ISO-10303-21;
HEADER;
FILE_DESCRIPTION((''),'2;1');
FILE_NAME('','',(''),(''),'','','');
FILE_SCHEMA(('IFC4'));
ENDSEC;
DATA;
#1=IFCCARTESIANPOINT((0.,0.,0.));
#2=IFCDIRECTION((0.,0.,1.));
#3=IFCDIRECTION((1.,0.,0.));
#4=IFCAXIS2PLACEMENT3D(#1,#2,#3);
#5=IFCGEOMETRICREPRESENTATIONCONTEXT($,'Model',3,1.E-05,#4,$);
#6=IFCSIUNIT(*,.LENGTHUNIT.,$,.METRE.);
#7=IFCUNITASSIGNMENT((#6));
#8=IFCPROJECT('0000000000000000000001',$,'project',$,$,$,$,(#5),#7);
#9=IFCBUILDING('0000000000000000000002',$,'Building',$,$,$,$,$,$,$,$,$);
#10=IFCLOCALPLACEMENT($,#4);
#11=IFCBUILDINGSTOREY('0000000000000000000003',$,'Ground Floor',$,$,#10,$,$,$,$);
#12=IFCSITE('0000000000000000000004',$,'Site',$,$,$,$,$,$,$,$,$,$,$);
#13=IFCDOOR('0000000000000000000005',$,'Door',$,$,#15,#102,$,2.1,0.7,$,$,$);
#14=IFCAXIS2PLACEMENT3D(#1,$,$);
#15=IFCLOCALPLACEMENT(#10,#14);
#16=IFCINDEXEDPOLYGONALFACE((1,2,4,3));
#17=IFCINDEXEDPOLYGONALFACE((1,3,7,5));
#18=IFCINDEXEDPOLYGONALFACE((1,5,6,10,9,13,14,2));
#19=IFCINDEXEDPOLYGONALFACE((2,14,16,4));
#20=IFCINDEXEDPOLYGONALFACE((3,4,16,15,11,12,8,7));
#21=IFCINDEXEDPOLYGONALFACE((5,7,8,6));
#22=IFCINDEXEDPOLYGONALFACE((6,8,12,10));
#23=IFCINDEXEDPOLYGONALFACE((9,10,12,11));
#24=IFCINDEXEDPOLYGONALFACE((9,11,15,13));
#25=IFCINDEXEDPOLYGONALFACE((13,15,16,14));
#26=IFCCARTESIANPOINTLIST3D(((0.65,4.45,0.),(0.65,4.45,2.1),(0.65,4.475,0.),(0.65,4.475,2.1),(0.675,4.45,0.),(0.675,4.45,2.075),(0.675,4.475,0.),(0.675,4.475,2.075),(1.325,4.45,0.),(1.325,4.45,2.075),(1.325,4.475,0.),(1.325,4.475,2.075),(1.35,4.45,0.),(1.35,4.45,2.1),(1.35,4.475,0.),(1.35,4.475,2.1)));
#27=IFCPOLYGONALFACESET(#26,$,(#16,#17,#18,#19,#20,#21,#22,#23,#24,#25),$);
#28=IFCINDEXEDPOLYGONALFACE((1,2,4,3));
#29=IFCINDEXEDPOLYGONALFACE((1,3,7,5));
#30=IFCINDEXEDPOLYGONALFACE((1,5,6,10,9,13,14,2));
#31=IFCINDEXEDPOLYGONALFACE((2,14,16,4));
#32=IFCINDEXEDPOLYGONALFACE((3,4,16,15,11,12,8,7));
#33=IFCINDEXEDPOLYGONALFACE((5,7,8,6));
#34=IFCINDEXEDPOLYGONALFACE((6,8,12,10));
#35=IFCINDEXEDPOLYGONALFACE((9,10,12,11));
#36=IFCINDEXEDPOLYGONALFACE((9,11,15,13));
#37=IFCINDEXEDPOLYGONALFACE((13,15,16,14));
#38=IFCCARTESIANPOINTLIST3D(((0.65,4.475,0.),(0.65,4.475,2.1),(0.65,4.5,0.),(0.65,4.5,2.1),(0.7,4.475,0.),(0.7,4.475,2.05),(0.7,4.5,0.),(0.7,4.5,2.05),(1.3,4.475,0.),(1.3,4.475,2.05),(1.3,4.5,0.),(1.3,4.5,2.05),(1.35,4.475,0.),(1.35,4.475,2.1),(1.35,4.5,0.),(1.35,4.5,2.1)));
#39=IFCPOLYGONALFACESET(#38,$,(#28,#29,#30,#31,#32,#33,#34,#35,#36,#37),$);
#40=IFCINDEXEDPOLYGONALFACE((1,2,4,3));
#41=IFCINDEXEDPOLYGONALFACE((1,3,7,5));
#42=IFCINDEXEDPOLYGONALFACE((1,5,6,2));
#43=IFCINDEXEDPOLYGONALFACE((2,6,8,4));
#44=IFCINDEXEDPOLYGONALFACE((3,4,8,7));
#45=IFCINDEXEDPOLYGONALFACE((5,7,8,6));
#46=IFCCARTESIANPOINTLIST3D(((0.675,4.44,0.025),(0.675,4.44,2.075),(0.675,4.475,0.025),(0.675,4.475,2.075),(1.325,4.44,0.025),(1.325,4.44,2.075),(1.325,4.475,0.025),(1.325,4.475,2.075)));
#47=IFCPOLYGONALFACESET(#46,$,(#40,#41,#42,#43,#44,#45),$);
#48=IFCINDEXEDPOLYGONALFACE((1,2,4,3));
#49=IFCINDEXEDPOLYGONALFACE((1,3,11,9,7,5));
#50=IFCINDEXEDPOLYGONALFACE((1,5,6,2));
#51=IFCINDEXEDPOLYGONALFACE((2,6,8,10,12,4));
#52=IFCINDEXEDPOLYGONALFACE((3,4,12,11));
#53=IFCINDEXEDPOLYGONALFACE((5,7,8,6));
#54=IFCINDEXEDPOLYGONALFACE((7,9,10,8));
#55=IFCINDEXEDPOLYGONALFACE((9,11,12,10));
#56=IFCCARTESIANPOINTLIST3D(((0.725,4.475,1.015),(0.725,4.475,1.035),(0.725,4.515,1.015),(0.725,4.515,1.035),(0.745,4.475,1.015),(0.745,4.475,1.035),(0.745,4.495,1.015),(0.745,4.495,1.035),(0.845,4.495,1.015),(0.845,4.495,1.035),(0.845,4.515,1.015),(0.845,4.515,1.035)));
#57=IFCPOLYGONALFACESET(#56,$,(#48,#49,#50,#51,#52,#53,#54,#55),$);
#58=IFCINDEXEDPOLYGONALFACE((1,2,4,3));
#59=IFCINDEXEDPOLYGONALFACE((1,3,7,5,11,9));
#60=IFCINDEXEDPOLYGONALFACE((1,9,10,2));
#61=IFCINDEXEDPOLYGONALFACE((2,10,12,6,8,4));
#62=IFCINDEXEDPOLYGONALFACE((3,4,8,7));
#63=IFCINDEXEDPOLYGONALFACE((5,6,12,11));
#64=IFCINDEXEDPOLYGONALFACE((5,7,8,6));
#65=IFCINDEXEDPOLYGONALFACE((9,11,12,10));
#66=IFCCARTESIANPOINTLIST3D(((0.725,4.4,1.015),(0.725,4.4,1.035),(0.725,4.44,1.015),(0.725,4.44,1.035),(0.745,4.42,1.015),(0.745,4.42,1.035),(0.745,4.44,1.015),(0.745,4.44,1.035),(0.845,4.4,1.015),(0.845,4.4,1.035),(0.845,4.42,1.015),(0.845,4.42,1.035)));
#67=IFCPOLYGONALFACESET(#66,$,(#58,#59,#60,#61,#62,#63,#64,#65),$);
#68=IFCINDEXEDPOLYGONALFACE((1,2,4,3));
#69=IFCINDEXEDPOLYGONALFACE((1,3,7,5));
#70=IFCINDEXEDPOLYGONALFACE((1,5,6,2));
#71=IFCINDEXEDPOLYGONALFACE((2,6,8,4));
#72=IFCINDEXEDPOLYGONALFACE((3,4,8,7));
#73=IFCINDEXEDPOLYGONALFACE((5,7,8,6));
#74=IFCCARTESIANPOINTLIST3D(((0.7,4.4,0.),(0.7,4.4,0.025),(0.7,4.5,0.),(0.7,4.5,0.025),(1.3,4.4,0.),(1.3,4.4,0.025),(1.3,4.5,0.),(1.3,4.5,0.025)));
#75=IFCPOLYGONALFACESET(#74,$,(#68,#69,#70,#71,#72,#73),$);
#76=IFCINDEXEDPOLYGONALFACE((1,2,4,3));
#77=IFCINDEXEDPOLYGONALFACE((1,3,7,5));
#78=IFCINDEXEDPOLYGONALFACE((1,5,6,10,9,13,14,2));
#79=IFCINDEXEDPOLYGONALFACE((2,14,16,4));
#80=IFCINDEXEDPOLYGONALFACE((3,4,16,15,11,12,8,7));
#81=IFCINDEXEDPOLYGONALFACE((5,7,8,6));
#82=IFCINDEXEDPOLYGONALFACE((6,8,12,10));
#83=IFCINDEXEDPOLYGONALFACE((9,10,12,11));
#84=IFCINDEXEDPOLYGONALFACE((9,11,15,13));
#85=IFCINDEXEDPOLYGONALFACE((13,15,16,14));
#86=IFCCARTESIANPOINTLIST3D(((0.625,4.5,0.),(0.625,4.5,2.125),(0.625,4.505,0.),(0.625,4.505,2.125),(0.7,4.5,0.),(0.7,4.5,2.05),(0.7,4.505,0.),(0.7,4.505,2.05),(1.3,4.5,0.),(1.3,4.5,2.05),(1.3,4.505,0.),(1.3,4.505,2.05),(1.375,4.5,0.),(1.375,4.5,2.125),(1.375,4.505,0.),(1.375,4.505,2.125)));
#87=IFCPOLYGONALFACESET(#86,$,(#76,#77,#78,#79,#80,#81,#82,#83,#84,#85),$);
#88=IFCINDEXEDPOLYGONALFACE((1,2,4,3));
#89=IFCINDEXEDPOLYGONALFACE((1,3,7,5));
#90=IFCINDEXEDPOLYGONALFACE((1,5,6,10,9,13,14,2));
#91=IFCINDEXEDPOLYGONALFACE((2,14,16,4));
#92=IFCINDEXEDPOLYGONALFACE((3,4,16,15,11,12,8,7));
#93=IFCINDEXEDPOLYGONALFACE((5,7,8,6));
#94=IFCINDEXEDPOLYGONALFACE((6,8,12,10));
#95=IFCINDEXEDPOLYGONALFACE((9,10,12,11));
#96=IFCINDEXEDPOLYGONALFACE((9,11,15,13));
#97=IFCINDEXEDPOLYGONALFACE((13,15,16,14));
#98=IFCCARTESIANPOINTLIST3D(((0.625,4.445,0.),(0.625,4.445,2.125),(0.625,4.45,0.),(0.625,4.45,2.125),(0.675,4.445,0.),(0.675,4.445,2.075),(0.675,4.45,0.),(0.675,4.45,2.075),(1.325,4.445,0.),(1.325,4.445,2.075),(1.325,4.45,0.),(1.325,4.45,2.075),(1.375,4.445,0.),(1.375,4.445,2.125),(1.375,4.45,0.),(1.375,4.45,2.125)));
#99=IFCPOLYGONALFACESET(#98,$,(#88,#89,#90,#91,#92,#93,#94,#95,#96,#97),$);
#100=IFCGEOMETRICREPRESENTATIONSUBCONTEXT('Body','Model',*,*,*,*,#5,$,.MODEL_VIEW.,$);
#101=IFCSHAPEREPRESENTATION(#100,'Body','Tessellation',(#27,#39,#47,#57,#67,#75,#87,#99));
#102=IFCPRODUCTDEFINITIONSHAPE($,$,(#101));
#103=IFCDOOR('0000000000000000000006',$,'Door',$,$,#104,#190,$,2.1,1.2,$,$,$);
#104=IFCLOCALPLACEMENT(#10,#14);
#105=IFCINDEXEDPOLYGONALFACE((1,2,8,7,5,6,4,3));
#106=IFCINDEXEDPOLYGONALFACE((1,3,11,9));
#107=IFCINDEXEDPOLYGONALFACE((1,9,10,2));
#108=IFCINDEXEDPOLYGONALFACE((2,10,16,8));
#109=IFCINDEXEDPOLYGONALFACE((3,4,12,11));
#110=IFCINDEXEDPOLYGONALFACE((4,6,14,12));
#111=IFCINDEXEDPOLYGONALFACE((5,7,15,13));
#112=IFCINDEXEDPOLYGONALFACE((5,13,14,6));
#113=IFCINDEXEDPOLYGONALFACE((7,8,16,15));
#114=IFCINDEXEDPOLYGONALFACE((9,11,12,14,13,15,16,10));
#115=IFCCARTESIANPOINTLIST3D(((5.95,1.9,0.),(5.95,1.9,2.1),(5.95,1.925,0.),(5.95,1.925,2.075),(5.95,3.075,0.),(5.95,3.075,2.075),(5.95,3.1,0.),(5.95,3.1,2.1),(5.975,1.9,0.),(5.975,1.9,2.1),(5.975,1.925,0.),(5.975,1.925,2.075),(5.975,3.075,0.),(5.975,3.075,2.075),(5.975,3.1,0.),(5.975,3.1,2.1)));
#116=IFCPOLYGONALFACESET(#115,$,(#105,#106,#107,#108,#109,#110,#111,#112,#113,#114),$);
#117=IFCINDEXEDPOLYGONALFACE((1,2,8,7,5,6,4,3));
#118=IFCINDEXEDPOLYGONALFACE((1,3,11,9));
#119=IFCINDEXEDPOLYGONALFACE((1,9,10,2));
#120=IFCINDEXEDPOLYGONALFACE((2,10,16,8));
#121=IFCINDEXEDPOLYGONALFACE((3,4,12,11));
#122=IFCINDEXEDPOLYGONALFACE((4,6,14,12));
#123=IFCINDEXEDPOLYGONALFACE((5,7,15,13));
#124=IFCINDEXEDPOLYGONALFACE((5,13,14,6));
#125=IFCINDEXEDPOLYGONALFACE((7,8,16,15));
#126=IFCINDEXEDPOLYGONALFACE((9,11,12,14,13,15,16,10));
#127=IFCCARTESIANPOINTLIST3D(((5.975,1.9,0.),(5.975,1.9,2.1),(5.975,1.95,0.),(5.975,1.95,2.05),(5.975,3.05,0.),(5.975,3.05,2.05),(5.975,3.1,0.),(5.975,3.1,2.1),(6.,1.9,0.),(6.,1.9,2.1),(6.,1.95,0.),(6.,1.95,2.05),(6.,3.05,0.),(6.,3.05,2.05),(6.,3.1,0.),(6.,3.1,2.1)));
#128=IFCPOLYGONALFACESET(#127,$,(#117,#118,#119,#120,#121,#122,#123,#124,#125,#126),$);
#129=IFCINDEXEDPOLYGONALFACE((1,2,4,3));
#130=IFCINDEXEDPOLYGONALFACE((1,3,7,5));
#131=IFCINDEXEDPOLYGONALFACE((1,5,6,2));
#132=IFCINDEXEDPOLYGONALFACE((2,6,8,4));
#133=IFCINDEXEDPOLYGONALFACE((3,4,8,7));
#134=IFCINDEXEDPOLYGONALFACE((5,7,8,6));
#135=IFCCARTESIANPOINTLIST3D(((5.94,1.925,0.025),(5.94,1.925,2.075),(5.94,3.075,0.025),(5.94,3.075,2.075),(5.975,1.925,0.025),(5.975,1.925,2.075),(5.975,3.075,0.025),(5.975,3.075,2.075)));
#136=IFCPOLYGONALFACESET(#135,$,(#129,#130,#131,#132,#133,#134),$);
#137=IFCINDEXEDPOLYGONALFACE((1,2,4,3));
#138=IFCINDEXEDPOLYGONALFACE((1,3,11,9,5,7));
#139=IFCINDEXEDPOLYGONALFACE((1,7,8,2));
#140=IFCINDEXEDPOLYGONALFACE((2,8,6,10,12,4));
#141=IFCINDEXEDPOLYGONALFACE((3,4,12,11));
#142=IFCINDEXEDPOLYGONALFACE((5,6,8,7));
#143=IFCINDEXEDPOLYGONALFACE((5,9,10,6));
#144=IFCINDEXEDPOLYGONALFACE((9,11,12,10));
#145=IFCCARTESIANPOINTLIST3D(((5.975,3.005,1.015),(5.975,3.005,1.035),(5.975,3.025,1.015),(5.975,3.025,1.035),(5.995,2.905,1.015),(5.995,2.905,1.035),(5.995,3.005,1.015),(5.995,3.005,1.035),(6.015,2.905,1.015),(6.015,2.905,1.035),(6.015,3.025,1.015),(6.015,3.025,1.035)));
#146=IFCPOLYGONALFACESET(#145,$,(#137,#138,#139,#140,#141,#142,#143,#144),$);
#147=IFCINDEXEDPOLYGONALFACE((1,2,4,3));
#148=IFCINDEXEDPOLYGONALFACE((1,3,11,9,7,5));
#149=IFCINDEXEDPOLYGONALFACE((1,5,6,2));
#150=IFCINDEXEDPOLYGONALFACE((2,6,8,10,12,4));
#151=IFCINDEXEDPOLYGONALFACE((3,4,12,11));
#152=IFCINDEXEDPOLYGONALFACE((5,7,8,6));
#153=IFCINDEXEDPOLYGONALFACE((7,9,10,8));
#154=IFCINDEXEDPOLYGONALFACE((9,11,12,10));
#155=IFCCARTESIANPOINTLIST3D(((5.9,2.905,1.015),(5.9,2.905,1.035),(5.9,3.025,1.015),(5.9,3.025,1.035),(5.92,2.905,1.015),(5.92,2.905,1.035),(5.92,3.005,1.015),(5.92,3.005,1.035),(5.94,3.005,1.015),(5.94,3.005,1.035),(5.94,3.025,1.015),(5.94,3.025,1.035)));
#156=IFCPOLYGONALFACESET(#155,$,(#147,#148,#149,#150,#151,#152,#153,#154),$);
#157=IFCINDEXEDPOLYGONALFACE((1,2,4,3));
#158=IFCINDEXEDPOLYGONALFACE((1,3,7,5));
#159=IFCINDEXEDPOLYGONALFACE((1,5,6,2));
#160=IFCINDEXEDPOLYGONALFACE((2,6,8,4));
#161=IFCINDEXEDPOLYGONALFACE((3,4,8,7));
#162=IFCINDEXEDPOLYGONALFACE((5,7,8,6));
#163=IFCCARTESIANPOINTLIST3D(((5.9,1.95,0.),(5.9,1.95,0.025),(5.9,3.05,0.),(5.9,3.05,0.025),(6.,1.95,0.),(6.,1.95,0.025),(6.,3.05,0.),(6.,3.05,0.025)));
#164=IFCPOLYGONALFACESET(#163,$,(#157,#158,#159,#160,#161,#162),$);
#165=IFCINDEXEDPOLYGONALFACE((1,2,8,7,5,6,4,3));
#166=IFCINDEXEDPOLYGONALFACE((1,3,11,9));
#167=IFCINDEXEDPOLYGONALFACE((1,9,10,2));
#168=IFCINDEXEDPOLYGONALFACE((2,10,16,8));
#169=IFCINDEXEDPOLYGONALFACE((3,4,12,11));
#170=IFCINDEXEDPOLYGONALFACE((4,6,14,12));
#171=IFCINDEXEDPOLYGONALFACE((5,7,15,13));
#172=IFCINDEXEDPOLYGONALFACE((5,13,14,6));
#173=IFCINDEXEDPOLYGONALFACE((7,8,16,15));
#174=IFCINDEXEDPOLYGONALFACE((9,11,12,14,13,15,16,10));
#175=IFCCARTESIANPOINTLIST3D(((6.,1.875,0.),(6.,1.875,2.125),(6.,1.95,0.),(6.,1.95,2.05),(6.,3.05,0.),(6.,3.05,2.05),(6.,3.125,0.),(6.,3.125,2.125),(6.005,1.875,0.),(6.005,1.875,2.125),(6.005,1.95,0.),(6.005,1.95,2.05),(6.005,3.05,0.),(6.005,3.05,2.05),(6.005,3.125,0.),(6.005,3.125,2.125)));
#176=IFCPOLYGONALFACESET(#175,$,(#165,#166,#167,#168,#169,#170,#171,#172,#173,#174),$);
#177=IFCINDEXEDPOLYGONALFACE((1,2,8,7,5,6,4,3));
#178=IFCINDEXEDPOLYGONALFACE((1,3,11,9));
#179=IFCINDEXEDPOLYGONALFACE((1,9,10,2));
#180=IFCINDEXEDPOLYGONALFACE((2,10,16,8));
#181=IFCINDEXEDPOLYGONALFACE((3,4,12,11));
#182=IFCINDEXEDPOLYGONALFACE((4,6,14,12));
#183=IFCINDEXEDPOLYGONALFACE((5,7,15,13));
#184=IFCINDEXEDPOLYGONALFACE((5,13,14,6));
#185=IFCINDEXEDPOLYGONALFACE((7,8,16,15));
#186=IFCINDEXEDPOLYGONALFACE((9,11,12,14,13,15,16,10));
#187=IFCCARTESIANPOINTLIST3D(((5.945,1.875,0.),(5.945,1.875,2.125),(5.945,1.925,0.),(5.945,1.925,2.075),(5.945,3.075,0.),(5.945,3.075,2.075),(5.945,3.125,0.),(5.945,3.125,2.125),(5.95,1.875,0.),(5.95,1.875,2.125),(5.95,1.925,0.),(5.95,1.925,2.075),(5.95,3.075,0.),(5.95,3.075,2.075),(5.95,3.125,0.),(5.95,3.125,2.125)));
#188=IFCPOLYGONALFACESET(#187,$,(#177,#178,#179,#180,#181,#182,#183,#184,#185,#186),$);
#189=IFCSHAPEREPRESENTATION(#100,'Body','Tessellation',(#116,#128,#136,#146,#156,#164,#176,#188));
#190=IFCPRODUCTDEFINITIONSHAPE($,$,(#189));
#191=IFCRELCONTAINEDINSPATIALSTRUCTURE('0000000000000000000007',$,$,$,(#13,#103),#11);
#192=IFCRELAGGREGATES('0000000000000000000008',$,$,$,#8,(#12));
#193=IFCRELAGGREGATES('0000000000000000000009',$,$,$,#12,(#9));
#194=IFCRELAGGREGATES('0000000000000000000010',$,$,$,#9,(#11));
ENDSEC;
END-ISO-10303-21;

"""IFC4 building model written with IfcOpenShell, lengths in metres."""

from ifc_helpers import new_model, si_unit, frame, origin_with_axes, place, context, subcontext, project, spatial, line, indexed_curve, outline, extrude, element, save


model = new_model("IFC4")

# Units and contexts
model_context = context("Model", 3, precision=1e-05, world=origin_with_axes())
body_context = subcontext(model_context, "Body", "Model", "MODEL_VIEW")
ifc_project = project(units=[si_unit("LENGTHUNIT", "METRE")], contexts=[model_context])

# Site, building, storey
site = spatial("IfcSite", under=ifc_project, Name="Site")
building = spatial("IfcBuilding", under=site, Name="Building")
storey_placement = place(None, origin_with_axes())
storey = spatial("IfcBuildingStorey", under=building, at=storey_placement, Name="Ground Floor")

# Doors
door_1_placement = place(storey_placement, frame((1.35, 4.5, 0.0), z_axis=(0.0, 0.0, 1.0), x_axis=(-1.0, 0.0, 0.0)))
element("IfcDoor", 1, at=door_1_placement, inside=storey, Name="Door", OverallHeight=2.1, OverallWidth=0.7, context=body_context, shape_type="SweptSolid", body=[
    extrude(outline(indexed_curve([(0.0, 0.0), (0.0, 2.1), (0.7, 2.1), (0.7, 0.0), (0.675, 0.0), (0.675, 2.075), (0.025, 2.075), (0.025, 0.0)], segments=[line(1, 2, 3, 4, 5, 6, 7, 8, 1)])), frame((0.0, 0.025, 0.0), z_axis=(0.0, -1.0, 0.0), x_axis=(1.0, 0.0, 0.0)), (0.0, 0.0, -1.0), 0.025),
    extrude(outline(indexed_curve([(0.0, 0.0), (0.0, 2.1), (0.7, 2.1), (0.7, 0.0), (0.65, 0.0), (0.65, 2.05), (0.05, 2.05), (0.05, 0.0)], segments=[line(1, 2, 3, 4, 5, 6, 7, 8, 1)])), frame((0.0, 0.0, 0.0), z_axis=(0.0, -1.0, 0.0), x_axis=(1.0, 0.0, 0.0)), (0.0, 0.0, -1.0), 0.025),
    extrude(outline(indexed_curve([(0.0, 0.0), (0.65, 0.0), (0.65, 0.035), (0.0, 0.035)], segments=[line(1, 2, 3, 4, 1)])), frame((0.025, 0.025, 0.025), z_axis=(0.0, 0.0, 1.0), x_axis=(1.0, 0.0, 0.0)), (0.0, 0.0, 1.0), 2.05),
    extrude(outline(indexed_curve([(0.0, 0.0), (0.0, -0.04), (-0.12, -0.04), (-0.12, -0.02), (-0.02, -0.02), (-0.02, 0.0)], segments=[line(1, 2, 3, 4, 5, 6, 1)])), frame((0.625, 0.025, 1.015), z_axis=(0.0, 0.0, 1.0), x_axis=(1.0, 0.0, 0.0)), (0.0, 0.0, 1.0), 0.02),
    extrude(outline(indexed_curve([(0.0, 0.0), (0.0, 0.04), (-0.12, 0.04), (-0.12, 0.02), (-0.02, 0.02), (-0.02, 0.0)], segments=[line(1, 2, 3, 4, 5, 6, 1)])), frame((0.625, 0.06, 1.015), z_axis=(0.0, 0.0, 1.0), x_axis=(1.0, 0.0, 0.0)), (0.0, 0.0, 1.0), 0.02),
    extrude(outline(indexed_curve([(0.0, 0.0), (0.6, 0.0), (0.6, 0.1), (0.0, 0.1)], segments=[line(1, 2, 3, 4, 1)])), frame((0.05, 0.0, 0.0), z_axis=(0.0, 0.0, 1.0), x_axis=(1.0, 0.0, 0.0)), (0.0, 0.0, 1.0), 0.025),
    extrude(outline(indexed_curve([(0.0, 0.0), (0.0, 2.125), (0.75, 2.125), (0.75, 0.0), (0.675, 0.0), (0.675, 2.05), (0.075, 2.05), (0.075, 0.0)], segments=[line(1, 2, 3, 4, 5, 6, 7, 8, 1)])), frame((-0.025, -0.005, 0.0), z_axis=(0.0, -1.0, 0.0), x_axis=(1.0, 0.0, 0.0)), (0.0, 0.0, -1.0), 0.005),
    extrude(outline(indexed_curve([(0.0, 0.0), (0.0, 2.125), (0.75, 2.125), (0.75, 0.0), (0.7, 0.0), (0.7, 2.075), (0.05, 2.075), (0.05, 0.0)], segments=[line(1, 2, 3, 4, 5, 6, 7, 8, 1)])), frame((-0.025, 0.05, 0.0), z_axis=(0.0, -1.0, 0.0), x_axis=(1.0, 0.0, 0.0)), (0.0, 0.0, -1.0), 0.005),
])
door_2_placement = place(storey_placement, frame((6.0, 1.9, 0.0), z_axis=(0.0, 0.0, 1.0), x_axis=(0.0, 1.0, 0.0)))
element("IfcDoor", 2, at=door_2_placement, inside=storey, Name="Door", OverallHeight=2.1, OverallWidth=1.2, context=body_context, shape_type="SweptSolid", body=[
    extrude(outline(indexed_curve([(0.0, 0.0), (0.0, 2.1), (1.2, 2.1), (1.2, 0.0), (1.175, 0.0), (1.175, 2.075), (0.025, 2.075), (0.025, 0.0)], segments=[line(1, 2, 3, 4, 5, 6, 7, 8, 1)])), frame((0.0, 0.025, 0.0), z_axis=(0.0, -1.0, 0.0), x_axis=(1.0, 0.0, 0.0)), (0.0, 0.0, -1.0), 0.025),
    extrude(outline(indexed_curve([(0.0, 0.0), (0.0, 2.1), (1.2, 2.1), (1.2, 0.0), (1.15, 0.0), (1.15, 2.05), (0.05, 2.05), (0.05, 0.0)], segments=[line(1, 2, 3, 4, 5, 6, 7, 8, 1)])), frame((0.0, 0.0, 0.0), z_axis=(0.0, -1.0, 0.0), x_axis=(1.0, 0.0, 0.0)), (0.0, 0.0, -1.0), 0.025),
    extrude(outline(indexed_curve([(0.0, 0.0), (1.15, 0.0), (1.15, 0.035), (0.0, 0.035)], segments=[line(1, 2, 3, 4, 1)])), frame((0.025, 0.025, 0.025), z_axis=(0.0, 0.0, 1.0), x_axis=(1.0, 0.0, 0.0)), (0.0, 0.0, 1.0), 2.05),
    extrude(outline(indexed_curve([(0.0, 0.0), (0.0, -0.04), (-0.12, -0.04), (-0.12, -0.02), (-0.02, -0.02), (-0.02, 0.0)], segments=[line(1, 2, 3, 4, 5, 6, 1)])), frame((1.125, 0.025, 1.015), z_axis=(0.0, 0.0, 1.0), x_axis=(1.0, 0.0, 0.0)), (0.0, 0.0, 1.0), 0.02),
    extrude(outline(indexed_curve([(0.0, 0.0), (0.0, 0.04), (-0.12, 0.04), (-0.12, 0.02), (-0.02, 0.02), (-0.02, 0.0)], segments=[line(1, 2, 3, 4, 5, 6, 1)])), frame((1.125, 0.06, 1.015), z_axis=(0.0, 0.0, 1.0), x_axis=(1.0, 0.0, 0.0)), (0.0, 0.0, 1.0), 0.02),
    extrude(outline(indexed_curve([(0.0, 0.0), (1.1, 0.0), (1.1, 0.1), (0.0, 0.1)], segments=[line(1, 2, 3, 4, 1)])), frame((0.05, 0.0, 0.0), z_axis=(0.0, 0.0, 1.0), x_axis=(1.0, 0.0, 0.0)), (0.0, 0.0, 1.0), 0.025),
    extrude(outline(indexed_curve([(0.0, 0.0), (0.0, 2.125), (1.25, 2.125), (1.25, 0.0), (1.175, 0.0), (1.175, 2.05), (0.075, 2.05), (0.075, 0.0)], segments=[line(1, 2, 3, 4, 5, 6, 7, 8, 1)])), frame((-0.025, -0.005, 0.0), z_axis=(0.0, -1.0, 0.0), x_axis=(1.0, 0.0, 0.0)), (0.0, 0.0, -1.0), 0.005),
    extrude(outline(indexed_curve([(0.0, 0.0), (0.0, 2.125), (1.25, 2.125), (1.25, 0.0), (1.2, 0.0), (1.2, 2.075), (0.05, 2.075), (0.05, 0.0)], segments=[line(1, 2, 3, 4, 5, 6, 7, 8, 1)])), frame((-0.025, 0.05, 0.0), z_axis=(0.0, -1.0, 0.0), x_axis=(1.0, 0.0, 0.0)), (0.0, 0.0, -1.0), 0.005),
])

save(model, "model.ifc")
